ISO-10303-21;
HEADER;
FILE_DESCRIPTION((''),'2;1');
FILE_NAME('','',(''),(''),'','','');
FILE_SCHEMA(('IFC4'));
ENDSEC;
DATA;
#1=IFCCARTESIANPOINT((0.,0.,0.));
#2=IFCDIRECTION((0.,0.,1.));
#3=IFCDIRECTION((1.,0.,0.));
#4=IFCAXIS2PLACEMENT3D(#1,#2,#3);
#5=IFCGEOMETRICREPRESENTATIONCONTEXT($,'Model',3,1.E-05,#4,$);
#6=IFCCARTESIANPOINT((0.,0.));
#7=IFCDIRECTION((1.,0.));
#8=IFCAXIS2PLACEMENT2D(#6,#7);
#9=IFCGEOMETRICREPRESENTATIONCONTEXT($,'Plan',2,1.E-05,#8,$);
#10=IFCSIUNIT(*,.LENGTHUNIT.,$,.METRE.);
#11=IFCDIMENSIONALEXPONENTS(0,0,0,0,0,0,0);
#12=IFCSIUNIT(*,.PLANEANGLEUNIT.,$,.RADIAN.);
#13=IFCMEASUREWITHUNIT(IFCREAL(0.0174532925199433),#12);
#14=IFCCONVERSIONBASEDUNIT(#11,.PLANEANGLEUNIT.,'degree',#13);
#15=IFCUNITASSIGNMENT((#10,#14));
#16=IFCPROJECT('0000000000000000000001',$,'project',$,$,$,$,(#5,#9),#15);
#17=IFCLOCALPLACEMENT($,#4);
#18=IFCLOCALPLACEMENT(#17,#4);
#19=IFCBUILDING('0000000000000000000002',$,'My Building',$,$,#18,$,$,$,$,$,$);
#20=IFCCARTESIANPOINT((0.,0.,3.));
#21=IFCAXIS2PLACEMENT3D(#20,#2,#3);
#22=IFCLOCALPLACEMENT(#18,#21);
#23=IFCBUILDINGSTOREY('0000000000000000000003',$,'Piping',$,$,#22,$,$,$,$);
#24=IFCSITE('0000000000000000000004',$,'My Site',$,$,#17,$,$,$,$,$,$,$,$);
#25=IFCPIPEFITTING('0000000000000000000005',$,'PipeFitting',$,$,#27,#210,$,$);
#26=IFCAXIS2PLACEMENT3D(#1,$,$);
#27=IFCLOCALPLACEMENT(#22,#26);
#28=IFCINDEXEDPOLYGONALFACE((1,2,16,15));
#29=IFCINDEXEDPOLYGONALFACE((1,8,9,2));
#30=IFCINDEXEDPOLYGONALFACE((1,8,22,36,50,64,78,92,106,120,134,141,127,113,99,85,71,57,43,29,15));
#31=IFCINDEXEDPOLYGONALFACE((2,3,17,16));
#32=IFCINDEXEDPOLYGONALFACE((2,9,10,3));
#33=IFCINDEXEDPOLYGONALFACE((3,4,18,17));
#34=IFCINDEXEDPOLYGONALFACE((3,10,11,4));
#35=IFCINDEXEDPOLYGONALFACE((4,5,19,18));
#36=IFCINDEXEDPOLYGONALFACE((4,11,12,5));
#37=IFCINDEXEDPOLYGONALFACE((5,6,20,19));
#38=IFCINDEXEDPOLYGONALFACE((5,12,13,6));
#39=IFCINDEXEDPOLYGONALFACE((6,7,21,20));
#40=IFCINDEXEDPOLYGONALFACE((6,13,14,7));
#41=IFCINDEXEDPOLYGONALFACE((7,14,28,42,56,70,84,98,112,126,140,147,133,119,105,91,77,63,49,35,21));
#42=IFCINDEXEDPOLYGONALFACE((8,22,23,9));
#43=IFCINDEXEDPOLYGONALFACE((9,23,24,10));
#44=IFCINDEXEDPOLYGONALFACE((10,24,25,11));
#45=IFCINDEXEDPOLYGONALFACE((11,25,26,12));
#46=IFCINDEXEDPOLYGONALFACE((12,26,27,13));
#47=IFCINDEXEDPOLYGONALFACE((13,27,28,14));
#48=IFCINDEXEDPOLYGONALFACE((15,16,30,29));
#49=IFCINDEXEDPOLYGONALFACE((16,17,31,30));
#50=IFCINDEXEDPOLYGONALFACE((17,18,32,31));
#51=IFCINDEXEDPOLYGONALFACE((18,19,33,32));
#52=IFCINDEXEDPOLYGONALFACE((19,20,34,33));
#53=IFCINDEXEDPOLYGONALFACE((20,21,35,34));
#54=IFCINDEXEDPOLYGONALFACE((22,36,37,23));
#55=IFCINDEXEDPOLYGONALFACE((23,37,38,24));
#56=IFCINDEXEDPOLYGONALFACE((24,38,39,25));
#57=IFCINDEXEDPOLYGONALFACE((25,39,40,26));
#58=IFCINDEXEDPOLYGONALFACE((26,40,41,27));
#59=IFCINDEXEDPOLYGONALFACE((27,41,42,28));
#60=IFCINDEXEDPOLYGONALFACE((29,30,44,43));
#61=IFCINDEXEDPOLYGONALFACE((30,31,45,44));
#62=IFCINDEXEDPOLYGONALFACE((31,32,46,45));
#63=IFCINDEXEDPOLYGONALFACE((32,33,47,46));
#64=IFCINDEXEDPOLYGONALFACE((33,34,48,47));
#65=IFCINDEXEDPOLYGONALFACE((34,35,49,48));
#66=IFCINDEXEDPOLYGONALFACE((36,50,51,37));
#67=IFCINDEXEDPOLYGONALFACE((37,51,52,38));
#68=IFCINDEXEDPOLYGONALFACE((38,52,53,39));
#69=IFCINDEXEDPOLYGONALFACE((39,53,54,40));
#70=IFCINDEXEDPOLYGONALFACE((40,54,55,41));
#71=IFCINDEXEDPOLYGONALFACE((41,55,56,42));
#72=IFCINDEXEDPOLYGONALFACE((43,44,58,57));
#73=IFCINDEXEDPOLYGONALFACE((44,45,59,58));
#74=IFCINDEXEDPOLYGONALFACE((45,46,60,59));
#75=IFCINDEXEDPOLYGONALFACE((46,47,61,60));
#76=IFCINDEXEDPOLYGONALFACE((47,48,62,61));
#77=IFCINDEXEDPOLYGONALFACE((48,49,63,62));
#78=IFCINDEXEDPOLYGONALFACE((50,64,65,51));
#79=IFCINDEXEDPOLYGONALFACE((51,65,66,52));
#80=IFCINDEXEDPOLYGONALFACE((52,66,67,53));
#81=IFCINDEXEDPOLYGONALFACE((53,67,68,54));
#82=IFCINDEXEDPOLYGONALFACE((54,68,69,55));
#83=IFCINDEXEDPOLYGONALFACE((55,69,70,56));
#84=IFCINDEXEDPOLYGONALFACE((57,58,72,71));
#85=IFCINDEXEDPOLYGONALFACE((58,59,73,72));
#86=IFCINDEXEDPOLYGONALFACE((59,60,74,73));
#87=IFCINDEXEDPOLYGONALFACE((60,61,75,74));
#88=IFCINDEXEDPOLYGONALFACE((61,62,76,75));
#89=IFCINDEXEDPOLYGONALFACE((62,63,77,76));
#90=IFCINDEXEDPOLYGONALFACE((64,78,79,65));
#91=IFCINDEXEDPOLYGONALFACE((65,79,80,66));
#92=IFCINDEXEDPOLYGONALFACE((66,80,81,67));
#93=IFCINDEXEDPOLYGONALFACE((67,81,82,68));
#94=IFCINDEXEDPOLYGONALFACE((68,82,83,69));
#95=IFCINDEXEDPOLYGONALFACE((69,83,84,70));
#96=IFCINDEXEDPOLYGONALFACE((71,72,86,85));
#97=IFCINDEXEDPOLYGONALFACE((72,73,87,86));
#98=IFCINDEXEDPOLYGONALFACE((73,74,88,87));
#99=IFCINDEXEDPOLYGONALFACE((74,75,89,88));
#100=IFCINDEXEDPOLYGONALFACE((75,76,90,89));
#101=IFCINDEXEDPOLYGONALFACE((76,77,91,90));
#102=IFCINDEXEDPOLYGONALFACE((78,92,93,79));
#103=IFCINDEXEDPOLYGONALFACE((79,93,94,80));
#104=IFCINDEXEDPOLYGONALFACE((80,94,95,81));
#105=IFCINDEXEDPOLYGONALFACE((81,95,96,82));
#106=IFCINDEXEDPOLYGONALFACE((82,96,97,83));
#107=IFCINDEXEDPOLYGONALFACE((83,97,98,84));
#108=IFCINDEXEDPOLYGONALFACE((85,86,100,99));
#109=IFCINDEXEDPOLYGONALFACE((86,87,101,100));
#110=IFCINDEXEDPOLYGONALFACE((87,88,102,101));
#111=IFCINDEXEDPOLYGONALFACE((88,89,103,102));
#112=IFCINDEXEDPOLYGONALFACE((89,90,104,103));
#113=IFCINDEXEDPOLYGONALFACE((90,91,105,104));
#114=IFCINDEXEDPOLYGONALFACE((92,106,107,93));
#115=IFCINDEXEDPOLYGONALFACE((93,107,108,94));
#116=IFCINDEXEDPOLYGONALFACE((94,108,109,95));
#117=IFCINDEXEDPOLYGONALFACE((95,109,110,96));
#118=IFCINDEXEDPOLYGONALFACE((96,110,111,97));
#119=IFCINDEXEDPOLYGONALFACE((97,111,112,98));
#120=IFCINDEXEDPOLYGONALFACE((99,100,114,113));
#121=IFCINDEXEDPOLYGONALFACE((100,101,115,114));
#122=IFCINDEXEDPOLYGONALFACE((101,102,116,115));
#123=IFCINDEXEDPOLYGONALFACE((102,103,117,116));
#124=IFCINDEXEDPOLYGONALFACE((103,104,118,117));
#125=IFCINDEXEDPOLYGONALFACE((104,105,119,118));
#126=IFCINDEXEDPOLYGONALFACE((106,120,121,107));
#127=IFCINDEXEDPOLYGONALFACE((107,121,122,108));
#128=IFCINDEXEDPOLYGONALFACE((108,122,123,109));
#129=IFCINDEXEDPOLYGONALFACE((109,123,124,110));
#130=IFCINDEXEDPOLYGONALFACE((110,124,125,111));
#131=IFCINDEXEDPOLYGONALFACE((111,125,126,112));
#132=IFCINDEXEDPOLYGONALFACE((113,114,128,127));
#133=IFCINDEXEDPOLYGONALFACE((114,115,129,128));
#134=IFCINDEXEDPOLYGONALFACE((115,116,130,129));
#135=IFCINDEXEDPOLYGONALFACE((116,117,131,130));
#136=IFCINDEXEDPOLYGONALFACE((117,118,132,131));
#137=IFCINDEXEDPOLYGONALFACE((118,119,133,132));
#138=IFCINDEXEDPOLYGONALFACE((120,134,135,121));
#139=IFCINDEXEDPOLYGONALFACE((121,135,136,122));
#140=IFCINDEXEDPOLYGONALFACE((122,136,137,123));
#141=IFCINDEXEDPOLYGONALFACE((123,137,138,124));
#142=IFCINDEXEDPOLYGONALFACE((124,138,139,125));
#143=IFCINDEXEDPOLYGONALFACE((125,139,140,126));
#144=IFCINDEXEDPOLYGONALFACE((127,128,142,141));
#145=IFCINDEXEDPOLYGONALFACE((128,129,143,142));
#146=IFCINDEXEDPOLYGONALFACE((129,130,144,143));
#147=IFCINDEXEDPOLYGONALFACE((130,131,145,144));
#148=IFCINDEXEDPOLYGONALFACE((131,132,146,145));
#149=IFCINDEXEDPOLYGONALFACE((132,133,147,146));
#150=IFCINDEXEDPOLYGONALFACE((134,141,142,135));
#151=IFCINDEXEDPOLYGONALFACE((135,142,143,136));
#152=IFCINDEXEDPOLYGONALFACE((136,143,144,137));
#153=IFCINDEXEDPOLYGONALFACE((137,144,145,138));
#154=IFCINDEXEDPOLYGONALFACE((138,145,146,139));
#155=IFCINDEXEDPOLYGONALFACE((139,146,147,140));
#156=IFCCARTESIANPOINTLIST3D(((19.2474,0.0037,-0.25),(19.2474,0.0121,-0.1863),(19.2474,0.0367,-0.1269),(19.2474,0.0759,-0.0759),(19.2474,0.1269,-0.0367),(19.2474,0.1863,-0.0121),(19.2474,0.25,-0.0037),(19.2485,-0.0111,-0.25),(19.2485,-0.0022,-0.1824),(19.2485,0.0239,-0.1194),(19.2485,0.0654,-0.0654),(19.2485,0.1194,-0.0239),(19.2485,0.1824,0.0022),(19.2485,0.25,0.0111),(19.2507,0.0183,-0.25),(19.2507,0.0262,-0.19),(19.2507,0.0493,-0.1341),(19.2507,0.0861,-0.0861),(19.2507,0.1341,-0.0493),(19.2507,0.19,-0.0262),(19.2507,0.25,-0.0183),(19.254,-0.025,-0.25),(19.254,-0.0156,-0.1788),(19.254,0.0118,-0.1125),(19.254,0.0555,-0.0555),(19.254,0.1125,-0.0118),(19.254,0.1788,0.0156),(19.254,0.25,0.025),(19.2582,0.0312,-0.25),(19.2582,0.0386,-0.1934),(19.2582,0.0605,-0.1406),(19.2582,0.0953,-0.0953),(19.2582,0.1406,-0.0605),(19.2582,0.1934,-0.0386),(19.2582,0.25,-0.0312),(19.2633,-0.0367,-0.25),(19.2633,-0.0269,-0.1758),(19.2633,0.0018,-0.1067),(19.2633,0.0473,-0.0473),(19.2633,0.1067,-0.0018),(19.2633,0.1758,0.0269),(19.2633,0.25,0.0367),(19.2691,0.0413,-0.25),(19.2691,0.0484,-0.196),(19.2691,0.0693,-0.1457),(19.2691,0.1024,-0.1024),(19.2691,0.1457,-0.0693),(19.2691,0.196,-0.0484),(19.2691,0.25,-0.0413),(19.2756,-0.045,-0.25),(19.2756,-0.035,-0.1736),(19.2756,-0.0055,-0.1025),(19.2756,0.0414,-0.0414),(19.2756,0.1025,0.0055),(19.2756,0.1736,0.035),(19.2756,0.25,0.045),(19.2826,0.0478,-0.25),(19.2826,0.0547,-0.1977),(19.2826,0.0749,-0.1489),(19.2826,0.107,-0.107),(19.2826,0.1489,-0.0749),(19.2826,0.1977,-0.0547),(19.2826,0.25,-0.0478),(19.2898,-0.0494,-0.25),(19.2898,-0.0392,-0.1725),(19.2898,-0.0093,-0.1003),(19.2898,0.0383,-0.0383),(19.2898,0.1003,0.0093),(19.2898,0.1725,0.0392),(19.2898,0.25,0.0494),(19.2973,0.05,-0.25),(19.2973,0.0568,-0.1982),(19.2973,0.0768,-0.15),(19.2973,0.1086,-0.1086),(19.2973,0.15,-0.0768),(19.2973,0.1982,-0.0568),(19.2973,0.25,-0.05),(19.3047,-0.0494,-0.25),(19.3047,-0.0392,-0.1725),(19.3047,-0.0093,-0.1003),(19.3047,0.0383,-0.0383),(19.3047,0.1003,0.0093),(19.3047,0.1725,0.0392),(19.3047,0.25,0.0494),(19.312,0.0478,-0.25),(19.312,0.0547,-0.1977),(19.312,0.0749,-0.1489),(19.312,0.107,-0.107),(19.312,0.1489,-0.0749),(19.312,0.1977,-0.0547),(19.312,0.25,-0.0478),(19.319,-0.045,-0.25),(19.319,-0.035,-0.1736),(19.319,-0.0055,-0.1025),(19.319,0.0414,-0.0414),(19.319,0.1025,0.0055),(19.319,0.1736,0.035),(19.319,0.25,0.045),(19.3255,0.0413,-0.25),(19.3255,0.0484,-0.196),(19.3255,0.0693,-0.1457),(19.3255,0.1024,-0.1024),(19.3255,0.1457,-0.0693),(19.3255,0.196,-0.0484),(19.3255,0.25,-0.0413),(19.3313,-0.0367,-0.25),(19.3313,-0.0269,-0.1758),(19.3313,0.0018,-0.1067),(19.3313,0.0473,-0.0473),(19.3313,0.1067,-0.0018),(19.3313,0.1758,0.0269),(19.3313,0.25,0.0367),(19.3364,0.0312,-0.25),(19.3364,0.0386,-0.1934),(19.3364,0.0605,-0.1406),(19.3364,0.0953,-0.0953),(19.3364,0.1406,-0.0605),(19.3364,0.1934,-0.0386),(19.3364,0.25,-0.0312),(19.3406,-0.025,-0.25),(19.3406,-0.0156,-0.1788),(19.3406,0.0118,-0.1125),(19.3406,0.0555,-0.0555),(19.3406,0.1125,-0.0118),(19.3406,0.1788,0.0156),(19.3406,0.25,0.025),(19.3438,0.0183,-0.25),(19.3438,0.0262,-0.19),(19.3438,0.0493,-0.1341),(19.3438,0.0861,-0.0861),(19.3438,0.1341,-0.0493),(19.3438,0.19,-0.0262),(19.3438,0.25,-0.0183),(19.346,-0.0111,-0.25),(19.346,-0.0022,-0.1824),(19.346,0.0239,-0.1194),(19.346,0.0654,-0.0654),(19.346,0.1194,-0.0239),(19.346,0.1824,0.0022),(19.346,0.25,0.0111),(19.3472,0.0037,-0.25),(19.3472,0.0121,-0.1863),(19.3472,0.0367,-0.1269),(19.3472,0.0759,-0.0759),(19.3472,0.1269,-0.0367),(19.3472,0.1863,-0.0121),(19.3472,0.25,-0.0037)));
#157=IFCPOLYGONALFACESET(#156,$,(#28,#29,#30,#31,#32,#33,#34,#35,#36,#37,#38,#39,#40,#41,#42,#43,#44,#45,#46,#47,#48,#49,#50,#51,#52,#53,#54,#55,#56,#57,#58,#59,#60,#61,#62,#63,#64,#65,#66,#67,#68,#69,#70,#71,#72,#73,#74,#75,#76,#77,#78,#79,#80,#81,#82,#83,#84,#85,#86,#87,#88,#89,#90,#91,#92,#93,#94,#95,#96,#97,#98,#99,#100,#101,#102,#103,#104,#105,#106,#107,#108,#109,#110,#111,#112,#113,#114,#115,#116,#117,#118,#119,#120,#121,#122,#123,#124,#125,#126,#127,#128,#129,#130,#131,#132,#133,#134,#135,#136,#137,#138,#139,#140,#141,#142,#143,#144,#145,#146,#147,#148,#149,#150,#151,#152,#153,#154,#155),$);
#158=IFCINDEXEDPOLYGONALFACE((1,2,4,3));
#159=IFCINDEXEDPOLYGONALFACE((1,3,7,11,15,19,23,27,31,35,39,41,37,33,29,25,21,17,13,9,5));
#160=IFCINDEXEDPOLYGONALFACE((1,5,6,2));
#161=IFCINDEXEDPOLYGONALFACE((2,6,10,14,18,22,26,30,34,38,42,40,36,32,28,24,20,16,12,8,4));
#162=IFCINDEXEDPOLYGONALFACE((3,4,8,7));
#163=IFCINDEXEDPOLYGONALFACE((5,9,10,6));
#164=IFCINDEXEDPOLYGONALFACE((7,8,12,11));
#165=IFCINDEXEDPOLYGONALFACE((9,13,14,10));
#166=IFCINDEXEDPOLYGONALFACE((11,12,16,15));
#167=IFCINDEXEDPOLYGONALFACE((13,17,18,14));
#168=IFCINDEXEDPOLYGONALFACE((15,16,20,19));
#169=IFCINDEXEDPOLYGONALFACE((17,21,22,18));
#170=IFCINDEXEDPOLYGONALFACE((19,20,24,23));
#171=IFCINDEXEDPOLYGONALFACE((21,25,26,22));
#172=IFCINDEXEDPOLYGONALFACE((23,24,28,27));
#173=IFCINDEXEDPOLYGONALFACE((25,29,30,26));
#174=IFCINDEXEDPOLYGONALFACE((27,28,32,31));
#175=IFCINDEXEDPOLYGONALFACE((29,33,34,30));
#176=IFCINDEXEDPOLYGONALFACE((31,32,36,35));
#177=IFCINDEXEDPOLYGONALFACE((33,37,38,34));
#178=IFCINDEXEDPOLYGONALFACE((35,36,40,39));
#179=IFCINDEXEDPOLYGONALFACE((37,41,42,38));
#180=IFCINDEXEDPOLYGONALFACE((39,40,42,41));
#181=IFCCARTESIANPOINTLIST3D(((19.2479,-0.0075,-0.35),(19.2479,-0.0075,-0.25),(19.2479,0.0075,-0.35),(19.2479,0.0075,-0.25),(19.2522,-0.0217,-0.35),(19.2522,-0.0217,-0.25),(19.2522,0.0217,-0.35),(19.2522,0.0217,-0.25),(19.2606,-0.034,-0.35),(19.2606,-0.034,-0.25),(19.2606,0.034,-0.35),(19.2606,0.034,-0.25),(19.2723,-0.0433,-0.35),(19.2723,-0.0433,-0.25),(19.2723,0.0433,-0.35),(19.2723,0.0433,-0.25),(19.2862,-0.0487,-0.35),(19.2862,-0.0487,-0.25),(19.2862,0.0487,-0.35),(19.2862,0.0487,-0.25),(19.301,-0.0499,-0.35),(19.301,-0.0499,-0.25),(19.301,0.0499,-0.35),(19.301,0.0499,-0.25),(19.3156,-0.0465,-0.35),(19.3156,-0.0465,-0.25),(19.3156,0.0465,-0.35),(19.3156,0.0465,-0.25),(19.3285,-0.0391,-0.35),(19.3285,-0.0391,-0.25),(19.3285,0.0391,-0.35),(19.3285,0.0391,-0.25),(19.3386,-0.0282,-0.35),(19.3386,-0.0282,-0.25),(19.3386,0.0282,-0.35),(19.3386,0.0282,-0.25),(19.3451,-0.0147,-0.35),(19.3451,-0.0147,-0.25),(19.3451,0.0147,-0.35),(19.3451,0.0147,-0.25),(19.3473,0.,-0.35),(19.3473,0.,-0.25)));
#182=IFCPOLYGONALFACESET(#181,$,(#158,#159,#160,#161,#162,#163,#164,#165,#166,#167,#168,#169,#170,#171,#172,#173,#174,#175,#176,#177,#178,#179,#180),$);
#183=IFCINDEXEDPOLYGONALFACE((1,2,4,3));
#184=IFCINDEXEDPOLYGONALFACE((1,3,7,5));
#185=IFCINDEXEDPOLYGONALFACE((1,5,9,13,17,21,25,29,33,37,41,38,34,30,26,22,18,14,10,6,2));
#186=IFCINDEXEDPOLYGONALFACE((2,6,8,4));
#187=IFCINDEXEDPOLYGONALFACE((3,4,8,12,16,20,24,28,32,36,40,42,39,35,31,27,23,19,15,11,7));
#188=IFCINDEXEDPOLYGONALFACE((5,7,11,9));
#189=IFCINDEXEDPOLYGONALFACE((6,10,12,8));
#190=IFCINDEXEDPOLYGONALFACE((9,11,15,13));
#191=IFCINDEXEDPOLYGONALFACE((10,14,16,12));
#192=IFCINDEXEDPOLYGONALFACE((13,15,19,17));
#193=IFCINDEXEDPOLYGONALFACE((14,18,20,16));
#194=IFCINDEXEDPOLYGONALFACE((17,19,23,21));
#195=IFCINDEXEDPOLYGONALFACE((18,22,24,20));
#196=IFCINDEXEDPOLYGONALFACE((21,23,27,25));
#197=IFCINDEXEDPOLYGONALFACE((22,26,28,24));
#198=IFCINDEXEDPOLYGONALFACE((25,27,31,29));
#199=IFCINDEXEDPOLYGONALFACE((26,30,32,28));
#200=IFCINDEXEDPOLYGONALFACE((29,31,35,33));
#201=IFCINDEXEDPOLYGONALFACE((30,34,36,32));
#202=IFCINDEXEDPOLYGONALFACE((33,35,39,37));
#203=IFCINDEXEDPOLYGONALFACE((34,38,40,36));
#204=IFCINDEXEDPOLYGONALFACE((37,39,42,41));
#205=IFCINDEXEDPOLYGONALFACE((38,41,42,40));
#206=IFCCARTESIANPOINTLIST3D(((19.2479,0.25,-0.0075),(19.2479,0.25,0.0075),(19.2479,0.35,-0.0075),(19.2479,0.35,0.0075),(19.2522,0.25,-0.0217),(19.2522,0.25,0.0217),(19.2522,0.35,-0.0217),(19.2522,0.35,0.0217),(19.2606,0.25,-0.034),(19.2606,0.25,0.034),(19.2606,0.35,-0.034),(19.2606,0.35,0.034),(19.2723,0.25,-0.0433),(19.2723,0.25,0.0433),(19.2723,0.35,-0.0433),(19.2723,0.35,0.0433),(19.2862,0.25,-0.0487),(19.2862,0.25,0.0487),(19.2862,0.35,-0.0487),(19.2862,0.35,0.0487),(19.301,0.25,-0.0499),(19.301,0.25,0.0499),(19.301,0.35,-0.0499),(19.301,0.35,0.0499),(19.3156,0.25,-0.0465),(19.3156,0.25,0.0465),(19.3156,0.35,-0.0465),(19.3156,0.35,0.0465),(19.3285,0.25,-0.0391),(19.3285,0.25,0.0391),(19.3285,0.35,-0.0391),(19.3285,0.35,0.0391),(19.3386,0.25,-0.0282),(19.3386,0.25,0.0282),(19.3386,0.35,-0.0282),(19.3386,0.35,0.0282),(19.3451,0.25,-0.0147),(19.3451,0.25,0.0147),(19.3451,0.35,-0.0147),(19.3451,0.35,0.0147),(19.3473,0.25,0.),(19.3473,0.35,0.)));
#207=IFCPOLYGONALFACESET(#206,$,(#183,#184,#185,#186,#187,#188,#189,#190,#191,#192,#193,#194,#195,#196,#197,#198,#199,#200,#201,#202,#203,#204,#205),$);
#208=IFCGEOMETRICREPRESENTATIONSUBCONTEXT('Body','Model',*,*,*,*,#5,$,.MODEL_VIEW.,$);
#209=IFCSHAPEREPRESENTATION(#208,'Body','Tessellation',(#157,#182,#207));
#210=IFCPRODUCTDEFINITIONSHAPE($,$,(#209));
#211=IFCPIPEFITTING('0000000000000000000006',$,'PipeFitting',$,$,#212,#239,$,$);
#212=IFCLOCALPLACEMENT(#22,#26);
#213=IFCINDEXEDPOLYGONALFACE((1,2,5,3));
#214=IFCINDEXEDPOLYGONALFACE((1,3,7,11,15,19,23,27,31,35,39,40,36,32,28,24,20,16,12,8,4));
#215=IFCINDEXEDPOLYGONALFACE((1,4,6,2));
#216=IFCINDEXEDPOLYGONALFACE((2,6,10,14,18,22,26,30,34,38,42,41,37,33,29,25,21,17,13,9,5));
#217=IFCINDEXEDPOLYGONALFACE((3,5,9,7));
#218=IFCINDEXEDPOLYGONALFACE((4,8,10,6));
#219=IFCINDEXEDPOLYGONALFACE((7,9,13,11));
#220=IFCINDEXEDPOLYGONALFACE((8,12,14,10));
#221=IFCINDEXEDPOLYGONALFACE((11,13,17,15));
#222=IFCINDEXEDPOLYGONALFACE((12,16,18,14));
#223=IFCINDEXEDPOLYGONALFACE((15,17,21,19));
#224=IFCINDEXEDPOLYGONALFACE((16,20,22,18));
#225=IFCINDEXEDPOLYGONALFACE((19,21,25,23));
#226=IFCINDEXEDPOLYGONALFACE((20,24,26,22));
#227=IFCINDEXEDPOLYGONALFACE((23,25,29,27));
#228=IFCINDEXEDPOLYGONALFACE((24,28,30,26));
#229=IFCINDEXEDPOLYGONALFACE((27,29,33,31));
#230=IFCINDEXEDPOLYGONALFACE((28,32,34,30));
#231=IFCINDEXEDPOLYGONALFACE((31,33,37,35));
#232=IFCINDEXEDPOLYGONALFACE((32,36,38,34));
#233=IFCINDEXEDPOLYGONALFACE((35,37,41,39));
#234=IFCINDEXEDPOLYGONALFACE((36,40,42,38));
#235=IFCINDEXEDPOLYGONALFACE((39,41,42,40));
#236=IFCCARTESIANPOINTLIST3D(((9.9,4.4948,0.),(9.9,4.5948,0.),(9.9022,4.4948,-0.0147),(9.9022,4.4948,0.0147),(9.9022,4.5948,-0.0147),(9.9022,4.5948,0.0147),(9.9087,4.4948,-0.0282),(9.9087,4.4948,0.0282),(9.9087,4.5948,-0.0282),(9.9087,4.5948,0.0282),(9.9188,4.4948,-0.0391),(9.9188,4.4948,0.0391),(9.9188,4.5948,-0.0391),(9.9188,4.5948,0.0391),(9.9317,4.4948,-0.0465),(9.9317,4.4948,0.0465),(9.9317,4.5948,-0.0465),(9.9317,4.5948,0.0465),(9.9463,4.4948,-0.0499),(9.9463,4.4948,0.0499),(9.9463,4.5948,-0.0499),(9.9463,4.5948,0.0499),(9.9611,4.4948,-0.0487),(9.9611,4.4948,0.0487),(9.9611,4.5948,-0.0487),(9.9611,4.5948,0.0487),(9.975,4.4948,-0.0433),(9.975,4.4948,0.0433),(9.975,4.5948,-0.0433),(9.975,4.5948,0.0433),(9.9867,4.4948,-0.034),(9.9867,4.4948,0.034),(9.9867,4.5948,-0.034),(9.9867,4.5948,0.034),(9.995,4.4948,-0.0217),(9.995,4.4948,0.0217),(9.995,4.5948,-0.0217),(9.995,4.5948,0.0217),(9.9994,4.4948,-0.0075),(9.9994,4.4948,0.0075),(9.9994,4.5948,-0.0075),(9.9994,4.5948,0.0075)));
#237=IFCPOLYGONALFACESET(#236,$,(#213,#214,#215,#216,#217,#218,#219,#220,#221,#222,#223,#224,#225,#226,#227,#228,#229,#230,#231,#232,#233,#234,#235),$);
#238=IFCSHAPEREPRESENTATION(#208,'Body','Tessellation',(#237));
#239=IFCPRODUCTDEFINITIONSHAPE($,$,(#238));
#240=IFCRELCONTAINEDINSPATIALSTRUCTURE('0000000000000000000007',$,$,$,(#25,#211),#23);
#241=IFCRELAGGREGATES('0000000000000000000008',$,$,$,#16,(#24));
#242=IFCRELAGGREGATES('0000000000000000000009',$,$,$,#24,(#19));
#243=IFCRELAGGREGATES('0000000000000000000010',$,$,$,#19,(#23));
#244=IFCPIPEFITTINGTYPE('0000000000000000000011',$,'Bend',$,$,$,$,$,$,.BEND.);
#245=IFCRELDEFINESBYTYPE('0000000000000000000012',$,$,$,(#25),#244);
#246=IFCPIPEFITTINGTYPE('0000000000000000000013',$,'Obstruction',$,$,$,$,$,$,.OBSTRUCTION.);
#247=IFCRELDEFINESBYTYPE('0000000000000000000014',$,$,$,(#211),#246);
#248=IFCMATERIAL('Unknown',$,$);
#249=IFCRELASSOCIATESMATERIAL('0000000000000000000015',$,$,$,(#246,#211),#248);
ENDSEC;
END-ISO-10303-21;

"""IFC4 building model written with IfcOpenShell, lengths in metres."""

from ifc_helpers import new_model, entity, si_unit, converted_unit, frame, origin_with_axes, origin_2d_with_axis, place, context, subcontext, project, spatial, circle, extrude, source, transform, mapped, material, material_profile, profile_set, profile_usage, type_object, type_shapes, element, save


model = new_model("IFC4")

# Units and contexts
model_context = context("Model", 3, precision=1e-05, world=origin_with_axes())
plan_context = context("Plan", 2, precision=1e-05, world=origin_2d_with_axis())
body_context = subcontext(model_context, "Body", "Model", "MODEL_VIEW")
ifc_project = project(units=[si_unit("LENGTHUNIT", "METRE"), converted_unit("PLANEANGLEUNIT", "degree", entity("IfcReal", 0.0174532925199433), si_unit("PLANEANGLEUNIT", "RADIAN"), dimensions=[0, 0, 0, 0, 0, 0, 0])], contexts=[model_context, plan_context])

# Site, building, storey
site_placement = place(None, origin_with_axes())
site = spatial("IfcSite", under=ifc_project, at=site_placement, Name="My Site")
building_placement = place(site_placement, origin_with_axes())
building = spatial("IfcBuilding", under=site, at=building_placement, Name="My Building")
storey_placement = place(building_placement, frame((0.0, 0.0, 3.0), z_axis=(0.0, 0.0, 1.0), x_axis=(1.0, 0.0, 0.0)))
storey = spatial("IfcBuildingStorey", under=building, at=storey_placement, Name="Piping")

# Shared definitions
ifc_material = material(Name="Unknown")

# Pipe fittings
pipe_fitting_type_1 = type_object("IfcPipeFittingType", Name="Bend", PredefinedType="BEND")
shared_shape = source(origin_with_axes(), body_context, "Body", "SolidModel", [
    entity("IfcSweptDiskSolid", entity("IfcIndexedPolyCurve", entity("IfcCartesianPointList3D", [[0.0, 0.0, -0.1], [0.0, -0.0732, -0.2768], [0.0, -0.25, -0.35]]), [entity("IfcArcIndex", [1, 2, 3])]), 0.05),
    extrude(circle(Radius=0.05), origin_with_axes(), (0.0, 0.0, -1.0), 0.1),
    extrude(circle(Radius=0.05), frame((0.0, -0.25, -0.35), z_axis=(0.0, -1.0, 0.0), x_axis=(1.0, 0.0, 0.0)), (0.0, 0.0, 1.0), 0.1),
])
type_shapes(pipe_fitting_type_1, [shared_shape])
for number, where, z_axis, x_axis, name in (
    (1, (19.2973, 0.0, -0.35), (0.0, 0.0, -1.0), (1.0, 0.0, 0.0), "PipeFitting"),
):
    element("IfcPipeFitting", number, at=place(storey_placement, frame(where, z_axis=z_axis, x_axis=x_axis)), inside=storey, type_object=pipe_fitting_type_1, Name=name, context=body_context, shape_type="MappedRepresentation", body=[
        mapped(shared_shape, transform((0.0, 0.0, 0.0), x_axis=(1.0, 0.0, 0.0), y_axis=(0.0, 1.0, 0.0), z_axis=(0.0, 0.0, 1.0), scale=1.0)),
    ])
ifc_material_profile_1 = material_profile(ifc_material, circle(Radius=0.05))
ifc_profile_set_1 = profile_set([ifc_material_profile_1])
ifc_profile_usage_1 = profile_usage(ifc_profile_set_1, cardinal=5)
pipe_fitting_type_2 = type_object("IfcPipeFittingType", Name="Obstruction", PredefinedType="OBSTRUCTION", material=ifc_profile_set_1)
pipe_fitting_1_placement = place(storey_placement, frame((9.95, 4.4948, 0.0), z_axis=(0.0, 1.0, 0.0), x_axis=(-1.0, 0.0, 0.0)))
element("IfcPipeFitting", 2, at=pipe_fitting_1_placement, inside=storey, type_object=pipe_fitting_type_2, material=ifc_profile_usage_1, Name="PipeFitting", context=body_context, shape_type="SweptSolid", body=[
    extrude(circle(Radius=0.05), origin_with_axes(), (0.0, 0.0, 1.0), 0.1),
])

save(model, "model.ifc")
